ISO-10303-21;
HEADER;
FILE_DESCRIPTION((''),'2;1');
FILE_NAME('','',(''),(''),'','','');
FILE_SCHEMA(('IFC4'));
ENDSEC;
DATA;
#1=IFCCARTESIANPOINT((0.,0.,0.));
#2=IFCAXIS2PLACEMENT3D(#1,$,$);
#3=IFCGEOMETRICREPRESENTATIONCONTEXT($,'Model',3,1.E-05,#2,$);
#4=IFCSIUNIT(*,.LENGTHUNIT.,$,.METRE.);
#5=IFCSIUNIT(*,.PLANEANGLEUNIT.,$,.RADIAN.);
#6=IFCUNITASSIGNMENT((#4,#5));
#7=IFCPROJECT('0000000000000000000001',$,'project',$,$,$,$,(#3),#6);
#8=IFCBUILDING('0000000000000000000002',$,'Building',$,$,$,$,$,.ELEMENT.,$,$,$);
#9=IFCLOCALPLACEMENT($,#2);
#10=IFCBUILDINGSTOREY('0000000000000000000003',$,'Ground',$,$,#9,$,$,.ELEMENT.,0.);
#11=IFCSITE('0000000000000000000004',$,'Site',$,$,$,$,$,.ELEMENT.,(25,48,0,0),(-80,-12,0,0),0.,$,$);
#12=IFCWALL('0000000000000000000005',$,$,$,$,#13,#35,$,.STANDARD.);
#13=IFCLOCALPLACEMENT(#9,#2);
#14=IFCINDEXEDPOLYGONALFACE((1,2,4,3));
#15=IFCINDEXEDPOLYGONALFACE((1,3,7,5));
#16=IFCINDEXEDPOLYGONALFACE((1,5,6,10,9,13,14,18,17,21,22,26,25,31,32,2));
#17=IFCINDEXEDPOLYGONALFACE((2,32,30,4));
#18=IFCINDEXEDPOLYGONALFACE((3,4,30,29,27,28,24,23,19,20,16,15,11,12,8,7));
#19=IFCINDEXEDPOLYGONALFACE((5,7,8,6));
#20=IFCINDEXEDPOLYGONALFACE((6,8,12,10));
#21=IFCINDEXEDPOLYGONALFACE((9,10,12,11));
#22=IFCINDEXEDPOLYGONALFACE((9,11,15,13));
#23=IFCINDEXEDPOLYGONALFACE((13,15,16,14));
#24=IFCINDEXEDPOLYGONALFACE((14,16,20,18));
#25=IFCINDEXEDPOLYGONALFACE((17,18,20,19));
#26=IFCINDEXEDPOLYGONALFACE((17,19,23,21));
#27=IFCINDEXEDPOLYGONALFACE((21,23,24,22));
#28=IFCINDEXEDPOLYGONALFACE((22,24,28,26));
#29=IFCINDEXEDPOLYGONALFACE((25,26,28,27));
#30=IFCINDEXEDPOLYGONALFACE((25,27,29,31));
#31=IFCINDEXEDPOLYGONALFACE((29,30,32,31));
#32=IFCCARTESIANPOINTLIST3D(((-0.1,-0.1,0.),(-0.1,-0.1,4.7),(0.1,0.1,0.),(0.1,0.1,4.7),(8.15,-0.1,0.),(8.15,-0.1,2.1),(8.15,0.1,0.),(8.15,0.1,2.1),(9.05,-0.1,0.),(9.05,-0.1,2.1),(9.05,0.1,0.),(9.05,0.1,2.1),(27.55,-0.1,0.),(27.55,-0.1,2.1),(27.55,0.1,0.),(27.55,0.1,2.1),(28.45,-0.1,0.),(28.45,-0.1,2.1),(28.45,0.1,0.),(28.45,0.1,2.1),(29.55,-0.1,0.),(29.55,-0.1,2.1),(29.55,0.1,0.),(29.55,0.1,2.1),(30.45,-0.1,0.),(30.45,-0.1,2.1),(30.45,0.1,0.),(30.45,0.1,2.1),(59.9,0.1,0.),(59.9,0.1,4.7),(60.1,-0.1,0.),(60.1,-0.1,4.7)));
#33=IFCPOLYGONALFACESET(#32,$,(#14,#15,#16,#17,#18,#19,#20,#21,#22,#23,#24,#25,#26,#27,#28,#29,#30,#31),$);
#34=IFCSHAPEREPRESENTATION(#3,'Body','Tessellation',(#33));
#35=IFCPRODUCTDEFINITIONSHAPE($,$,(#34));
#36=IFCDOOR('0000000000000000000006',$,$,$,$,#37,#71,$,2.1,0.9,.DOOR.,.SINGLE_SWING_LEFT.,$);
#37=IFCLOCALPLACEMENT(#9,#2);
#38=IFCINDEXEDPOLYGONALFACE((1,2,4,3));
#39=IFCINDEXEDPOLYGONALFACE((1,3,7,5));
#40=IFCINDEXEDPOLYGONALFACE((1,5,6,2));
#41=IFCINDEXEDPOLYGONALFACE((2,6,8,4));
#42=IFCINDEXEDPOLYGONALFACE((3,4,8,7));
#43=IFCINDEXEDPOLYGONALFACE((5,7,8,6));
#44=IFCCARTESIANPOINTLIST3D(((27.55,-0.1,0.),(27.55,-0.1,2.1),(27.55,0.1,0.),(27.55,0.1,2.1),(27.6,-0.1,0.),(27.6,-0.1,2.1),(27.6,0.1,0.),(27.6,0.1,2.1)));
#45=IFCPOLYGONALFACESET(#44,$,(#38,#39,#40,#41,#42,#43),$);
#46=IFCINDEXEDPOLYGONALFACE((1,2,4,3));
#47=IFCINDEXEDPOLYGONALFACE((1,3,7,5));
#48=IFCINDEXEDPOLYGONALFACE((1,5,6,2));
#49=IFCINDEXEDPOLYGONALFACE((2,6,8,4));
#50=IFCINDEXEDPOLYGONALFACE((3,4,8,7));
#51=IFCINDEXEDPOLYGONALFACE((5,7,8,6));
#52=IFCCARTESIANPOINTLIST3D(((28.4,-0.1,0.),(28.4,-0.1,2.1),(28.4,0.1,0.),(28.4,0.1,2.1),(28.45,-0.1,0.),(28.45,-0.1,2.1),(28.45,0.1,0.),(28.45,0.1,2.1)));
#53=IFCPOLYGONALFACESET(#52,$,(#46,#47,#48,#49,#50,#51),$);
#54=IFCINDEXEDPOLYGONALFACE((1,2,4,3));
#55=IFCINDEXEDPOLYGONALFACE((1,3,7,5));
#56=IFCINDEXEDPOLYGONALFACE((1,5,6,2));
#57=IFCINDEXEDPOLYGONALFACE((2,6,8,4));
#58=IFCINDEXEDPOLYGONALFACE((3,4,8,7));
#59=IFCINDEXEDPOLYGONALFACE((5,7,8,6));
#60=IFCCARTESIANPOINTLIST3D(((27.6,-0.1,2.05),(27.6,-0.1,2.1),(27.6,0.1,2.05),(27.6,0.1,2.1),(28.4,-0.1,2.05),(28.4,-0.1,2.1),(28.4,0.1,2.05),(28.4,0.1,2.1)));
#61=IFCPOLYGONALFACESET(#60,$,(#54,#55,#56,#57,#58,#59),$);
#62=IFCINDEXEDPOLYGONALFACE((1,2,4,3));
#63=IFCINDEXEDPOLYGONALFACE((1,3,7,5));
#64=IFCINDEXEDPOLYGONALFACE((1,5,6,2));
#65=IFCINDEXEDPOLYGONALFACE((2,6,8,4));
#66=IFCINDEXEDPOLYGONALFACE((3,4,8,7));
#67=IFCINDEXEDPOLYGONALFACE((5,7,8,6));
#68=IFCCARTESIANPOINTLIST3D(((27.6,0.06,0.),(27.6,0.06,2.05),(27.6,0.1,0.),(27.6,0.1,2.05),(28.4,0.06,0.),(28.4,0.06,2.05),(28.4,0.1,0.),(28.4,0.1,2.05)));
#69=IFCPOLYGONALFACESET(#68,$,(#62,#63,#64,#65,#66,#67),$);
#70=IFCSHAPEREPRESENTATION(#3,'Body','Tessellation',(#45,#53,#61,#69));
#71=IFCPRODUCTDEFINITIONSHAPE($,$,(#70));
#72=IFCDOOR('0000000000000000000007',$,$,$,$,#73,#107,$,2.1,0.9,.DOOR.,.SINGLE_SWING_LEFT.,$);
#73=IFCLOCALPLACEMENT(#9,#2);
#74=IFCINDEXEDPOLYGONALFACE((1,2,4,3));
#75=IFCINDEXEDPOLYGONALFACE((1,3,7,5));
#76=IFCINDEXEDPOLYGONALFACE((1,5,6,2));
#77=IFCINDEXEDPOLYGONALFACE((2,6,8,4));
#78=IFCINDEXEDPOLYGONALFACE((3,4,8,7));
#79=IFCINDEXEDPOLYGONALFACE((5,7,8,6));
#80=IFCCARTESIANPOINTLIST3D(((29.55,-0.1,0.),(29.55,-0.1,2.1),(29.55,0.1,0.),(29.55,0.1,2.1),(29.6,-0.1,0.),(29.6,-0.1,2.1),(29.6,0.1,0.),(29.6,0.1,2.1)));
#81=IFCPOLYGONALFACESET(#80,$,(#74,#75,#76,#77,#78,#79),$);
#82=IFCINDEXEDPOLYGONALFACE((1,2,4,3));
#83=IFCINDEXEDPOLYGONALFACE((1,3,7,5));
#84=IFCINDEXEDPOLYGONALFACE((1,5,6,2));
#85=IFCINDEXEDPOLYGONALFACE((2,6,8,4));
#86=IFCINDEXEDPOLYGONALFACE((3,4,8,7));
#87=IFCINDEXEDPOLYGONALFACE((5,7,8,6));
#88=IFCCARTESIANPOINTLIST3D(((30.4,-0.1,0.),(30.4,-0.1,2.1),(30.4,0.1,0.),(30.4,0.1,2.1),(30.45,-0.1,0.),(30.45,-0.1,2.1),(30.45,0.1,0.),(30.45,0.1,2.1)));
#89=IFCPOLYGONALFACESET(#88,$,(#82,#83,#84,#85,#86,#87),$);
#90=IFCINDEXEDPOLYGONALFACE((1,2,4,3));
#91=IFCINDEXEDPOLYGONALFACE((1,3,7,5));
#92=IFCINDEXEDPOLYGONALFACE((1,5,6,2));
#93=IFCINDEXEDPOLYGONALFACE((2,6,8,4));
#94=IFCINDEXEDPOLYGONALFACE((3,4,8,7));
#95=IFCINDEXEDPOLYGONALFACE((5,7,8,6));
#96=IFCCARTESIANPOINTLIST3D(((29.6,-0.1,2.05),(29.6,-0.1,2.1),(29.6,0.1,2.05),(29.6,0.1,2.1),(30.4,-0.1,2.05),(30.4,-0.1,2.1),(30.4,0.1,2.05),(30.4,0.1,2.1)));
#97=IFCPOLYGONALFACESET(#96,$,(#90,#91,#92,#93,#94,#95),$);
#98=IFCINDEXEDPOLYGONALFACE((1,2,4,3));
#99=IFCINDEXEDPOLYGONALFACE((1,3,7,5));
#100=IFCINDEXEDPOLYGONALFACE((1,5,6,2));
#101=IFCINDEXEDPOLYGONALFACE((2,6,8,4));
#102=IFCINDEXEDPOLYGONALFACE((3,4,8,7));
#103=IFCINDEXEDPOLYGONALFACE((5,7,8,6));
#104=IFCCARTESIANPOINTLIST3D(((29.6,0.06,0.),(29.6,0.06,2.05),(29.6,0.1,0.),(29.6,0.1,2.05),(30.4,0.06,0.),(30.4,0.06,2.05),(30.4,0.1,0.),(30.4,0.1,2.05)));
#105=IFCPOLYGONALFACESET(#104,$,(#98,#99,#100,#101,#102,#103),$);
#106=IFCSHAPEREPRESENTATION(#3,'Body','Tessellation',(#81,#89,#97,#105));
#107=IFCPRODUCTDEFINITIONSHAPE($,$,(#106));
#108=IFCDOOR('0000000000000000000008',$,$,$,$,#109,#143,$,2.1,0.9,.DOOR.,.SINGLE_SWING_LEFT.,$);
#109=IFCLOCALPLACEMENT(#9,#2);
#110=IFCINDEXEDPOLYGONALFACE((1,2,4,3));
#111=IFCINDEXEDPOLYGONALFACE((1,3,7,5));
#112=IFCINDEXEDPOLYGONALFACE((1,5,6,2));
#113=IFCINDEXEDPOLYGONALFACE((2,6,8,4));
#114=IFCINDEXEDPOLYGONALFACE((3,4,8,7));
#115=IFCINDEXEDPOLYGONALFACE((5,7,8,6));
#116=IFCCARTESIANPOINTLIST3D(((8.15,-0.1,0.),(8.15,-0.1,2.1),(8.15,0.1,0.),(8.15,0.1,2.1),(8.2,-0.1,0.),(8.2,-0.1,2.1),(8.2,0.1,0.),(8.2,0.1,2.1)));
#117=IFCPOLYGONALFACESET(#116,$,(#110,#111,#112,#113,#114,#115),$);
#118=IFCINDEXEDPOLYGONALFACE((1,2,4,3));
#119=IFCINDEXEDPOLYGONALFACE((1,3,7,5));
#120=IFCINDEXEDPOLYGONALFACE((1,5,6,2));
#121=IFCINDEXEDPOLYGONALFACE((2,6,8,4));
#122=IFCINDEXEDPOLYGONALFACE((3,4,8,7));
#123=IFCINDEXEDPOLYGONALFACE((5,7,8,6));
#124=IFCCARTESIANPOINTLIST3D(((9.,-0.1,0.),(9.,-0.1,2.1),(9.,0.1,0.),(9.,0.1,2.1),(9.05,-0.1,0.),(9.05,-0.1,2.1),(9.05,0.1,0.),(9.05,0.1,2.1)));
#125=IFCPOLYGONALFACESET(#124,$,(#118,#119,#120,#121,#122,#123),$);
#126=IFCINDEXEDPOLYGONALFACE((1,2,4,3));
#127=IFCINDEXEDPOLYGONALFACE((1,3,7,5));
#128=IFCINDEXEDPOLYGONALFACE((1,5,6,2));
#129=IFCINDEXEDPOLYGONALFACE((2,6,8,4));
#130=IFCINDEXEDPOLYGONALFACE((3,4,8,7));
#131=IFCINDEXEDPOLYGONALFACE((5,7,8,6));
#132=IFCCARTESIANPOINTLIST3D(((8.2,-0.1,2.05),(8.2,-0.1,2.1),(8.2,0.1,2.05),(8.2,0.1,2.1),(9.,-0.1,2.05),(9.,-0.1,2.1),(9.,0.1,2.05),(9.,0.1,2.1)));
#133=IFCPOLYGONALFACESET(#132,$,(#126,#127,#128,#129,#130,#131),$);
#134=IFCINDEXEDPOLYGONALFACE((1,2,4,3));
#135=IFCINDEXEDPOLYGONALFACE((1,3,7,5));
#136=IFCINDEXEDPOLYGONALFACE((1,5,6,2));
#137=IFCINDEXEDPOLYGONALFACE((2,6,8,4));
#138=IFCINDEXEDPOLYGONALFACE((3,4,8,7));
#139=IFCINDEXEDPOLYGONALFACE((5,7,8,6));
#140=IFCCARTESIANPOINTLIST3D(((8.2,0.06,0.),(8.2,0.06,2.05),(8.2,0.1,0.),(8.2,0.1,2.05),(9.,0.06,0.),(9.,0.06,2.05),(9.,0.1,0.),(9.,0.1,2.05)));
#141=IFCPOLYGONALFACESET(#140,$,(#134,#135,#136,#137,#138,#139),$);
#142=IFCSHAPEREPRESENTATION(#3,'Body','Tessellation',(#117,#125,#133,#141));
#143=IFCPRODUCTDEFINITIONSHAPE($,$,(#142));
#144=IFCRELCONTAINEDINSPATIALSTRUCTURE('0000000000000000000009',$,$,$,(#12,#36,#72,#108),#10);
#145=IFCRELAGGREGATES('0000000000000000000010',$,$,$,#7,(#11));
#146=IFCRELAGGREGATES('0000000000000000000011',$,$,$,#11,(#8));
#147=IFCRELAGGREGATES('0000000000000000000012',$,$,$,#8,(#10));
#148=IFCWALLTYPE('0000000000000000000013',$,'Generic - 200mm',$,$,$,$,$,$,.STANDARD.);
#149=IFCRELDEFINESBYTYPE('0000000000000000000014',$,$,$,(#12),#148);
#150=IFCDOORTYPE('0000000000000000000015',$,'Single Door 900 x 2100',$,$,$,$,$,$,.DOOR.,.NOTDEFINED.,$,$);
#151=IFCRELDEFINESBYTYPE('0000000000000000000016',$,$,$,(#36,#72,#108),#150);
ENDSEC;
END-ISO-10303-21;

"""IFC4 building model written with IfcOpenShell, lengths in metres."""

from ifc_helpers import new_model, si_unit, frame, frame_2d, origin, origin_with_axes, origin_2d, place, context, project, spatial, polyline, rectangle, outline, extrude, type_object, element, fill, save


model = new_model("IFC4")

# Units and contexts
model_context = context("Model", 3, precision=1e-05, world=origin())
ifc_project = project(units=[si_unit("LENGTHUNIT", "METRE"), si_unit("PLANEANGLEUNIT", "RADIAN")], contexts=[model_context])

# Site, building, storey
site = spatial("IfcSite", under=ifc_project, Name="Site", CompositionType="ELEMENT", RefLatitude=(25, 48, 0, 0), RefLongitude=(-80, -12, 0, 0), RefElevation=0.0)
building = spatial("IfcBuilding", under=site, Name="Building", CompositionType="ELEMENT")
storey_placement = place(None, origin())
storey = spatial("IfcBuildingStorey", under=building, at=storey_placement, Name="Ground", CompositionType="ELEMENT", Elevation=0.0)

# Wall, openings, doors
wall_type_1 = type_object("IfcWallType", Name="Generic - 200mm", PredefinedType="STANDARD")
wall_1_placement = place(None, origin_with_axes())
wall_1 = element("IfcWall", 1, at=wall_1_placement, inside=storey, type_object=wall_type_1, PredefinedType="STANDARD", context=model_context, shape_type="SweptSolid", body=[
    extrude(outline(polyline([(-0.1, -0.1), (60.1, -0.1), (59.9, 0.1), (0.1, 0.1), (-0.1, -0.1)])), origin(), (0.0, 0.0, 1.0), 4.7),
])
opening_1_placement = place(wall_1_placement, frame((28.0, 0.0, 0.0), z_axis=(0.0, 0.0, 1.0), x_axis=(1.0, 0.0, 0.0)))
opening_1 = element("IfcOpeningElement", 2, at=opening_1_placement, cuts=wall_1, PredefinedType="OPENING", context=model_context, shape_type="SweptSolid", body=[
    extrude(rectangle(XDim=0.9, YDim=0.202, at=origin_2d()), origin(), (0.0, 0.0, 1.0), 2.1),
])
opening_2_placement = place(wall_1_placement, frame((30.0, 0.0, 0.0), z_axis=(0.0, 0.0, 1.0), x_axis=(1.0, 0.0, 0.0)))
opening_2 = element("IfcOpeningElement", 3, at=opening_2_placement, cuts=wall_1, PredefinedType="OPENING", context=model_context, shape_type="SweptSolid", body=[
    extrude(rectangle(XDim=0.9, YDim=0.202, at=origin_2d()), origin(), (0.0, 0.0, 1.0), 2.1),
])
opening_3_placement = place(wall_1_placement, frame((8.6, 0.0, 0.0), z_axis=(0.0, 0.0, 1.0), x_axis=(1.0, 0.0, 0.0)))
opening_3 = element("IfcOpeningElement", 4, at=opening_3_placement, cuts=wall_1, PredefinedType="OPENING", context=model_context, shape_type="SweptSolid", body=[
    extrude(rectangle(XDim=0.9, YDim=0.202, at=origin_2d()), origin(), (0.0, 0.0, 1.0), 2.1),
])
door_type = type_object("IfcDoorType", Name="Single Door 900 x 2100", OperationType="NOTDEFINED", PredefinedType="DOOR")
door_1_placement = place(opening_1_placement, origin_with_axes())
door_1 = element("IfcDoor", 5, at=door_1_placement, inside=storey, type_object=door_type, OperationType="SINGLE_SWING_LEFT", OverallHeight=2.1, OverallWidth=0.9, PredefinedType="DOOR", context=model_context, shape_type="SweptSolid", body=[
    extrude(rectangle(XDim=0.05, YDim=0.2, at=frame_2d((-0.425, 0.0))), origin(), (0.0, 0.0, 1.0), 2.1),
    extrude(rectangle(XDim=0.05, YDim=0.2, at=frame_2d((0.425, 0.0))), origin(), (0.0, 0.0, 1.0), 2.1),
    extrude(rectangle(XDim=0.8, YDim=0.2, at=origin_2d()), frame((0.0, 0.0, 2.05)), (0.0, 0.0, 1.0), 0.05),
    extrude(rectangle(XDim=0.8, YDim=0.04, at=frame_2d((0.0, 0.08))), origin(), (0.0, 0.0, 1.0), 2.05),
])
fill(opening_1, door_1)
door_2_placement = place(opening_2_placement, origin_with_axes())
door_2 = element("IfcDoor", 6, at=door_2_placement, inside=storey, type_object=door_type, OperationType="SINGLE_SWING_LEFT", OverallHeight=2.1, OverallWidth=0.9, PredefinedType="DOOR", context=model_context, shape_type="SweptSolid", body=[
    extrude(rectangle(XDim=0.05, YDim=0.2, at=frame_2d((-0.425, 0.0))), origin(), (0.0, 0.0, 1.0), 2.1),
    extrude(rectangle(XDim=0.05, YDim=0.2, at=frame_2d((0.425, 0.0))), origin(), (0.0, 0.0, 1.0), 2.1),
    extrude(rectangle(XDim=0.8, YDim=0.2, at=origin_2d()), frame((0.0, 0.0, 2.05)), (0.0, 0.0, 1.0), 0.05),
    extrude(rectangle(XDim=0.8, YDim=0.04, at=frame_2d((0.0, 0.08))), origin(), (0.0, 0.0, 1.0), 2.05),
])
fill(opening_2, door_2)
door_3_placement = place(opening_3_placement, origin_with_axes())
door_3 = element("IfcDoor", 7, at=door_3_placement, inside=storey, type_object=door_type, OperationType="SINGLE_SWING_LEFT", OverallHeight=2.1, OverallWidth=0.9, PredefinedType="DOOR", context=model_context, shape_type="SweptSolid", body=[
    extrude(rectangle(XDim=0.05, YDim=0.2, at=frame_2d((-0.425, 0.0))), origin(), (0.0, 0.0, 1.0), 2.1),
    extrude(rectangle(XDim=0.05, YDim=0.2, at=frame_2d((0.425, 0.0))), origin(), (0.0, 0.0, 1.0), 2.1),
    extrude(rectangle(XDim=0.8, YDim=0.2, at=origin_2d()), frame((0.0, 0.0, 2.05)), (0.0, 0.0, 1.0), 0.05),
    extrude(rectangle(XDim=0.8, YDim=0.04, at=frame_2d((0.0, 0.08))), origin(), (0.0, 0.0, 1.0), 2.05),
])
fill(opening_3, door_3)

save(model, "model.ifc")
